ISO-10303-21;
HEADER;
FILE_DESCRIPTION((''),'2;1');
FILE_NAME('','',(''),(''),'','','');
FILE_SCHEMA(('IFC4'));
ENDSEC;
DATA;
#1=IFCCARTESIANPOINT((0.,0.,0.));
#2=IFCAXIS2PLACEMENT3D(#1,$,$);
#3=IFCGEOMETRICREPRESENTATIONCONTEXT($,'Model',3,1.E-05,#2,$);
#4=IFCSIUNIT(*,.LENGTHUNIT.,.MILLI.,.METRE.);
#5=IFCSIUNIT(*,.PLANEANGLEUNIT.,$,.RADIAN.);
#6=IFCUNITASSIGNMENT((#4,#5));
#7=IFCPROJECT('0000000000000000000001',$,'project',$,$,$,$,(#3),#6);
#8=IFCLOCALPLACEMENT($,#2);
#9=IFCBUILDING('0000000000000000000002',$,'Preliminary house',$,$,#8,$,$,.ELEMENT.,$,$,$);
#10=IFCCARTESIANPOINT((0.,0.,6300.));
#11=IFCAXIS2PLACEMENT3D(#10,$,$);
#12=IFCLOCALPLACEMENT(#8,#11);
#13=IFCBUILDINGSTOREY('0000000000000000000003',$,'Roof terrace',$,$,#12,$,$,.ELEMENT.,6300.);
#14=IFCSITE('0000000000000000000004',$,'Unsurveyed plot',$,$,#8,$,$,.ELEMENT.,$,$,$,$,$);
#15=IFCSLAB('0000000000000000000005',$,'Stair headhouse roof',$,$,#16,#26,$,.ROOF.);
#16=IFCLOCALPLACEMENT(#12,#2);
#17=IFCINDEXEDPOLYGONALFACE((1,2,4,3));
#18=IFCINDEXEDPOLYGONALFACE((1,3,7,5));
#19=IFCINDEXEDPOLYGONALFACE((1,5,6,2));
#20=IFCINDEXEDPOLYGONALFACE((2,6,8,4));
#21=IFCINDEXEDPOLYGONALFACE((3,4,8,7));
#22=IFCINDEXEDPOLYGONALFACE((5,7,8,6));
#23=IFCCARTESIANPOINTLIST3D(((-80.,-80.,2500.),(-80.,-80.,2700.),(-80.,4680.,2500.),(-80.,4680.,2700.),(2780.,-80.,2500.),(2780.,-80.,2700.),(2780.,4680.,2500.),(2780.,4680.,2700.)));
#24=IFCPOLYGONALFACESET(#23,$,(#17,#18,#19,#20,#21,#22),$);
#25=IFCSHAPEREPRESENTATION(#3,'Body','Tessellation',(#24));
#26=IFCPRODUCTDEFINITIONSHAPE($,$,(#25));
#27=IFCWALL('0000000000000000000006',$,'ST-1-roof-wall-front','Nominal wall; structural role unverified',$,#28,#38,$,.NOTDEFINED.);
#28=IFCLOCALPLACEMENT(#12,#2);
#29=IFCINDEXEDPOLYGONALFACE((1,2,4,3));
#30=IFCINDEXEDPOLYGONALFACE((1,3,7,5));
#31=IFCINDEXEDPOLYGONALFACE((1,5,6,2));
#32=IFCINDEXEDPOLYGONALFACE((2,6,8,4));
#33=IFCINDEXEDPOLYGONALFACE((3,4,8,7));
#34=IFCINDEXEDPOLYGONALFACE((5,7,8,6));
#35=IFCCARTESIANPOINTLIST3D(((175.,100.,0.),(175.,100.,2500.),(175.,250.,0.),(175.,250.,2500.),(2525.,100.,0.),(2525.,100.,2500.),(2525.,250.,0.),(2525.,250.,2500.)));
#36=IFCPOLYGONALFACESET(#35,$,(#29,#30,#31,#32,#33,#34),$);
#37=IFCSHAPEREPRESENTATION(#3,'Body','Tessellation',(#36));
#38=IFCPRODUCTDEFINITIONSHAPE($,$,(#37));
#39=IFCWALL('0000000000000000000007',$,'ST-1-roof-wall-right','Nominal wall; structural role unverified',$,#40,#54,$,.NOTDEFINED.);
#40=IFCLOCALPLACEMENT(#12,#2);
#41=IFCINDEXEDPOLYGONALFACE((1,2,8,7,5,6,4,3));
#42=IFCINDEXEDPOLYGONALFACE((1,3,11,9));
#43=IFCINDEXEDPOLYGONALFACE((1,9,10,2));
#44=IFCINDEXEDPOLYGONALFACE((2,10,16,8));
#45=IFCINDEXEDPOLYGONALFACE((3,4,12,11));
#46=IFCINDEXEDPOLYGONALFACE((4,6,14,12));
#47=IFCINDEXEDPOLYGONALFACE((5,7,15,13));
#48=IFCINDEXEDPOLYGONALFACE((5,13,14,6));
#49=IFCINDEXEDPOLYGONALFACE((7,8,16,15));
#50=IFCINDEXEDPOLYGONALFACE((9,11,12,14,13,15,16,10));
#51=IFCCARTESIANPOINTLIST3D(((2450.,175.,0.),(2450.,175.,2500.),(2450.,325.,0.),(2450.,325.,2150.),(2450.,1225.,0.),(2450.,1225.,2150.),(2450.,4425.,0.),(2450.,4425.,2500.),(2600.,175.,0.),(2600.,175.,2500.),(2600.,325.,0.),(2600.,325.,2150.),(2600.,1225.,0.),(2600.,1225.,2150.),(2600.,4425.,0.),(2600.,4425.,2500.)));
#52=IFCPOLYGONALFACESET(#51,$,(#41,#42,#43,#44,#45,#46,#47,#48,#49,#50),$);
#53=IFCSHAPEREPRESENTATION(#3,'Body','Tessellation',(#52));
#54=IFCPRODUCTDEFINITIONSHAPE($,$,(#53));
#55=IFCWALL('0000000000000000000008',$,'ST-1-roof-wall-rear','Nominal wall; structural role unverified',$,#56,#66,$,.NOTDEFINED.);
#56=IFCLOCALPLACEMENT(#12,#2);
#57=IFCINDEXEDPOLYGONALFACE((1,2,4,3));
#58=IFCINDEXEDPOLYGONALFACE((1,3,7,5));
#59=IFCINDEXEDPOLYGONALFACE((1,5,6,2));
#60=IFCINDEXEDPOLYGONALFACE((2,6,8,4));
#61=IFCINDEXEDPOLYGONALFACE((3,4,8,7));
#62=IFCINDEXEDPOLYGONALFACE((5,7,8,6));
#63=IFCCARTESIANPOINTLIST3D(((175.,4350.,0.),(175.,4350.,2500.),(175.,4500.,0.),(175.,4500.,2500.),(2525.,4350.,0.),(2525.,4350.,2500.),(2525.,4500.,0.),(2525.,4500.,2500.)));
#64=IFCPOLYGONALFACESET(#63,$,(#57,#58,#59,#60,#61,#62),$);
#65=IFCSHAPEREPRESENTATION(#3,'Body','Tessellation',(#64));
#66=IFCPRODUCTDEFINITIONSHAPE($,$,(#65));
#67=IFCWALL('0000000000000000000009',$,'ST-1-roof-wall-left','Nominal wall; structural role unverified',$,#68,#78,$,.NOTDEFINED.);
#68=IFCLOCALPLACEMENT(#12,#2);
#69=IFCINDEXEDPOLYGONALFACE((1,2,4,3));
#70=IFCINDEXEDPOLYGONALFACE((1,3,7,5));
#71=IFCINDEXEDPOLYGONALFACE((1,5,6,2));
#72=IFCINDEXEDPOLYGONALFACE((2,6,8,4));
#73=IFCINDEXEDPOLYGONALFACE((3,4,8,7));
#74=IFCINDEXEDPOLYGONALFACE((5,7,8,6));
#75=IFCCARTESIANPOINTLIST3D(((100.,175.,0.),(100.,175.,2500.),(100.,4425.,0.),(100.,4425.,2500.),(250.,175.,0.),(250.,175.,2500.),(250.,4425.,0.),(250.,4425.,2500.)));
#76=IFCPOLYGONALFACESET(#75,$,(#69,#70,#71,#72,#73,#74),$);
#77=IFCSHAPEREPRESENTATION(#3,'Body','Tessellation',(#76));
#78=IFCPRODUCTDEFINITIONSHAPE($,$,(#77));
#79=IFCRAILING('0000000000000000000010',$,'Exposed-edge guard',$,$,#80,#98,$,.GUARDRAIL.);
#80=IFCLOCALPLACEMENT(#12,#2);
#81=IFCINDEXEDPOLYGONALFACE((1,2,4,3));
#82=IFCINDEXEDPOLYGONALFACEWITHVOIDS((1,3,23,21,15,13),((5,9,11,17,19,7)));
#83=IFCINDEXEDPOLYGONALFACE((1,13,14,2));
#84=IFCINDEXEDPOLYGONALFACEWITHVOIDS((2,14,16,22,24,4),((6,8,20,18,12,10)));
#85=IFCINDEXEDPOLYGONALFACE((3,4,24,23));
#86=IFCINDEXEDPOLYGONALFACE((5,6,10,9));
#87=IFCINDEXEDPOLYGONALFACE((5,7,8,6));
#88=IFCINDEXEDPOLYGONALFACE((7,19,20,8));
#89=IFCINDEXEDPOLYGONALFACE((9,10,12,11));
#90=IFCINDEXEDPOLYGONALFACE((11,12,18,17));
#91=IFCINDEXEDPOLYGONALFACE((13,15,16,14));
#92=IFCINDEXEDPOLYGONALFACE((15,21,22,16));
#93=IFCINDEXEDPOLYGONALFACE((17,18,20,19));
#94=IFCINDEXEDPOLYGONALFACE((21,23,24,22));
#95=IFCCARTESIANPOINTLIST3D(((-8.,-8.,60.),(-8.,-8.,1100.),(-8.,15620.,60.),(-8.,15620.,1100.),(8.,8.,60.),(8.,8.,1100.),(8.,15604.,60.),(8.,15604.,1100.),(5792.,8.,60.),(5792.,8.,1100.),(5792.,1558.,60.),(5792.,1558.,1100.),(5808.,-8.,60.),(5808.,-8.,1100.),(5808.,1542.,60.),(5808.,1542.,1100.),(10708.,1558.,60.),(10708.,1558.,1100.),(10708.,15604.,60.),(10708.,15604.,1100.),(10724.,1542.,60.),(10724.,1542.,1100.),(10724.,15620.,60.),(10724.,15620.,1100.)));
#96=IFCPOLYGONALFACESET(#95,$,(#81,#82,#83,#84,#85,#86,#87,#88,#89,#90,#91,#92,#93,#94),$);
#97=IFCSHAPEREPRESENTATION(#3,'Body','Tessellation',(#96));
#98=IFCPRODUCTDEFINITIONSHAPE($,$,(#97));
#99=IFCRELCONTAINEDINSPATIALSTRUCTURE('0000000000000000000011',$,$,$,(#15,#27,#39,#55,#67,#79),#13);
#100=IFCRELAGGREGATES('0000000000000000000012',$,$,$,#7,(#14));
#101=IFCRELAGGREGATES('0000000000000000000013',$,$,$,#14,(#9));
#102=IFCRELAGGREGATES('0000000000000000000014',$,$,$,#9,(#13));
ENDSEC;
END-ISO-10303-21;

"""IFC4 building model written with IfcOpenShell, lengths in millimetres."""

from ifc_helpers import new_model, si_unit, frame, origin, place, context, project, spatial, polyline, outline, extrude, element, save


model = new_model("IFC4")

# Units and contexts
model_context = context("Model", 3, precision=1e-05, world=origin())
ifc_project = project(units=[si_unit("LENGTHUNIT", "METRE", prefix="MILLI"), si_unit("PLANEANGLEUNIT", "RADIAN")], contexts=[model_context])

# Site, building, storey
placement_1 = place(None, origin())
site = spatial("IfcSite", under=ifc_project, at=placement_1, Name="Unsurveyed plot", CompositionType="ELEMENT")
building = spatial("IfcBuilding", under=site, at=placement_1, Name="Preliminary house", CompositionType="ELEMENT")
placement_2 = place(placement_1, frame((0.0, 0.0, 6300.0)))
storey = spatial("IfcBuildingStorey", under=building, at=placement_2, Name="Roof terrace", CompositionType="ELEMENT", Elevation=6300.0)

# Slab
element("IfcSlab", 1, at=placement_2, inside=storey, Name="Stair headhouse roof", PredefinedType="ROOF", context=model_context, shape_type="SweptSolid", body=[
    extrude(outline(polyline([(2780.0, -80.0), (-80.0, -80.0), (-80.0, 4680.0), (2780.0, 4680.0), (2780.0, -80.0)])), frame((0.0, 0.0, 2500.0)), (0.0, 0.0, 1.0), 200.0),
])

# Wall
element("IfcWall", 2, at=placement_2, inside=storey, Name="ST-1-roof-wall-front", Description="Nominal wall; structural role unverified", PredefinedType="NOTDEFINED", context=model_context, shape_type="SweptSolid", body=[
    extrude(outline(polyline([(2525.0, 250.0), (2525.0, 100.0), (175.0, 100.0), (175.0, 250.0), (2525.0, 250.0)])), origin(), (0.0, 0.0, 1.0), 2500.0),
])

# Wall, opening
wall_1 = element("IfcWall", 3, at=placement_2, inside=storey, Name="ST-1-roof-wall-right", Description="Nominal wall; structural role unverified", PredefinedType="NOTDEFINED", context=model_context, shape_type="SweptSolid", body=[
    extrude(outline(polyline([(2450.0, 4425.0), (2600.0, 4425.0), (2600.0, 175.0), (2450.0, 175.0), (2450.0, 4425.0)])), origin(), (0.0, 0.0, 1.0), 2500.0),
])
element("IfcOpeningElement", 4, at=placement_2, cuts=wall_1, PredefinedType="OPENING", context=model_context, shape_type="SweptSolid", body=[
    extrude(outline(polyline([(2975.0, 325.0), (2975.0, 1225.0), (2075.0, 1225.0), (2075.0, 325.0), (2975.0, 325.0)])), origin(), (0.0, 0.0, 1.0), 2150.0),
])

# Walls
element("IfcWall", 5, at=placement_2, inside=storey, Name="ST-1-roof-wall-rear", Description="Nominal wall; structural role unverified", PredefinedType="NOTDEFINED", context=model_context, shape_type="SweptSolid", body=[
    extrude(outline(polyline([(2525.0, 4500.0), (2525.0, 4350.0), (175.0, 4350.0), (175.0, 4500.0), (2525.0, 4500.0)])), origin(), (0.0, 0.0, 1.0), 2500.0),
])
element("IfcWall", 6, at=placement_2, inside=storey, Name="ST-1-roof-wall-left", Description="Nominal wall; structural role unverified", PredefinedType="NOTDEFINED", context=model_context, shape_type="SweptSolid", body=[
    extrude(outline(polyline([(100.0, 4425.0), (250.0, 4425.0), (250.0, 175.0), (100.0, 175.0), (100.0, 4425.0)])), origin(), (0.0, 0.0, 1.0), 2500.0),
])

# Railing
element("IfcRailing", 7, at=placement_2, inside=storey, Name="Exposed-edge guard", PredefinedType="GUARDRAIL", context=model_context, shape_type="SweptSolid", body=[
    extrude(outline(polyline([(-8.0, -8.0), (-8.0, 15620.0), (10724.0, 15620.0), (10724.0, 1542.0), (5808.0, 1542.0), (5808.0, -8.0), (-8.0, -8.0)]), holes=[polyline([(8.0, 8.0), (5792.0, 8.0), (5792.0, 1558.0), (10708.0, 1558.0), (10708.0, 15604.0), (8.0, 15604.0), (8.0, 8.0)])]), frame((0.0, 0.0, 60.0)), (0.0, 0.0, 1.0), 1040.0),
])

save(model, "model.ifc")
